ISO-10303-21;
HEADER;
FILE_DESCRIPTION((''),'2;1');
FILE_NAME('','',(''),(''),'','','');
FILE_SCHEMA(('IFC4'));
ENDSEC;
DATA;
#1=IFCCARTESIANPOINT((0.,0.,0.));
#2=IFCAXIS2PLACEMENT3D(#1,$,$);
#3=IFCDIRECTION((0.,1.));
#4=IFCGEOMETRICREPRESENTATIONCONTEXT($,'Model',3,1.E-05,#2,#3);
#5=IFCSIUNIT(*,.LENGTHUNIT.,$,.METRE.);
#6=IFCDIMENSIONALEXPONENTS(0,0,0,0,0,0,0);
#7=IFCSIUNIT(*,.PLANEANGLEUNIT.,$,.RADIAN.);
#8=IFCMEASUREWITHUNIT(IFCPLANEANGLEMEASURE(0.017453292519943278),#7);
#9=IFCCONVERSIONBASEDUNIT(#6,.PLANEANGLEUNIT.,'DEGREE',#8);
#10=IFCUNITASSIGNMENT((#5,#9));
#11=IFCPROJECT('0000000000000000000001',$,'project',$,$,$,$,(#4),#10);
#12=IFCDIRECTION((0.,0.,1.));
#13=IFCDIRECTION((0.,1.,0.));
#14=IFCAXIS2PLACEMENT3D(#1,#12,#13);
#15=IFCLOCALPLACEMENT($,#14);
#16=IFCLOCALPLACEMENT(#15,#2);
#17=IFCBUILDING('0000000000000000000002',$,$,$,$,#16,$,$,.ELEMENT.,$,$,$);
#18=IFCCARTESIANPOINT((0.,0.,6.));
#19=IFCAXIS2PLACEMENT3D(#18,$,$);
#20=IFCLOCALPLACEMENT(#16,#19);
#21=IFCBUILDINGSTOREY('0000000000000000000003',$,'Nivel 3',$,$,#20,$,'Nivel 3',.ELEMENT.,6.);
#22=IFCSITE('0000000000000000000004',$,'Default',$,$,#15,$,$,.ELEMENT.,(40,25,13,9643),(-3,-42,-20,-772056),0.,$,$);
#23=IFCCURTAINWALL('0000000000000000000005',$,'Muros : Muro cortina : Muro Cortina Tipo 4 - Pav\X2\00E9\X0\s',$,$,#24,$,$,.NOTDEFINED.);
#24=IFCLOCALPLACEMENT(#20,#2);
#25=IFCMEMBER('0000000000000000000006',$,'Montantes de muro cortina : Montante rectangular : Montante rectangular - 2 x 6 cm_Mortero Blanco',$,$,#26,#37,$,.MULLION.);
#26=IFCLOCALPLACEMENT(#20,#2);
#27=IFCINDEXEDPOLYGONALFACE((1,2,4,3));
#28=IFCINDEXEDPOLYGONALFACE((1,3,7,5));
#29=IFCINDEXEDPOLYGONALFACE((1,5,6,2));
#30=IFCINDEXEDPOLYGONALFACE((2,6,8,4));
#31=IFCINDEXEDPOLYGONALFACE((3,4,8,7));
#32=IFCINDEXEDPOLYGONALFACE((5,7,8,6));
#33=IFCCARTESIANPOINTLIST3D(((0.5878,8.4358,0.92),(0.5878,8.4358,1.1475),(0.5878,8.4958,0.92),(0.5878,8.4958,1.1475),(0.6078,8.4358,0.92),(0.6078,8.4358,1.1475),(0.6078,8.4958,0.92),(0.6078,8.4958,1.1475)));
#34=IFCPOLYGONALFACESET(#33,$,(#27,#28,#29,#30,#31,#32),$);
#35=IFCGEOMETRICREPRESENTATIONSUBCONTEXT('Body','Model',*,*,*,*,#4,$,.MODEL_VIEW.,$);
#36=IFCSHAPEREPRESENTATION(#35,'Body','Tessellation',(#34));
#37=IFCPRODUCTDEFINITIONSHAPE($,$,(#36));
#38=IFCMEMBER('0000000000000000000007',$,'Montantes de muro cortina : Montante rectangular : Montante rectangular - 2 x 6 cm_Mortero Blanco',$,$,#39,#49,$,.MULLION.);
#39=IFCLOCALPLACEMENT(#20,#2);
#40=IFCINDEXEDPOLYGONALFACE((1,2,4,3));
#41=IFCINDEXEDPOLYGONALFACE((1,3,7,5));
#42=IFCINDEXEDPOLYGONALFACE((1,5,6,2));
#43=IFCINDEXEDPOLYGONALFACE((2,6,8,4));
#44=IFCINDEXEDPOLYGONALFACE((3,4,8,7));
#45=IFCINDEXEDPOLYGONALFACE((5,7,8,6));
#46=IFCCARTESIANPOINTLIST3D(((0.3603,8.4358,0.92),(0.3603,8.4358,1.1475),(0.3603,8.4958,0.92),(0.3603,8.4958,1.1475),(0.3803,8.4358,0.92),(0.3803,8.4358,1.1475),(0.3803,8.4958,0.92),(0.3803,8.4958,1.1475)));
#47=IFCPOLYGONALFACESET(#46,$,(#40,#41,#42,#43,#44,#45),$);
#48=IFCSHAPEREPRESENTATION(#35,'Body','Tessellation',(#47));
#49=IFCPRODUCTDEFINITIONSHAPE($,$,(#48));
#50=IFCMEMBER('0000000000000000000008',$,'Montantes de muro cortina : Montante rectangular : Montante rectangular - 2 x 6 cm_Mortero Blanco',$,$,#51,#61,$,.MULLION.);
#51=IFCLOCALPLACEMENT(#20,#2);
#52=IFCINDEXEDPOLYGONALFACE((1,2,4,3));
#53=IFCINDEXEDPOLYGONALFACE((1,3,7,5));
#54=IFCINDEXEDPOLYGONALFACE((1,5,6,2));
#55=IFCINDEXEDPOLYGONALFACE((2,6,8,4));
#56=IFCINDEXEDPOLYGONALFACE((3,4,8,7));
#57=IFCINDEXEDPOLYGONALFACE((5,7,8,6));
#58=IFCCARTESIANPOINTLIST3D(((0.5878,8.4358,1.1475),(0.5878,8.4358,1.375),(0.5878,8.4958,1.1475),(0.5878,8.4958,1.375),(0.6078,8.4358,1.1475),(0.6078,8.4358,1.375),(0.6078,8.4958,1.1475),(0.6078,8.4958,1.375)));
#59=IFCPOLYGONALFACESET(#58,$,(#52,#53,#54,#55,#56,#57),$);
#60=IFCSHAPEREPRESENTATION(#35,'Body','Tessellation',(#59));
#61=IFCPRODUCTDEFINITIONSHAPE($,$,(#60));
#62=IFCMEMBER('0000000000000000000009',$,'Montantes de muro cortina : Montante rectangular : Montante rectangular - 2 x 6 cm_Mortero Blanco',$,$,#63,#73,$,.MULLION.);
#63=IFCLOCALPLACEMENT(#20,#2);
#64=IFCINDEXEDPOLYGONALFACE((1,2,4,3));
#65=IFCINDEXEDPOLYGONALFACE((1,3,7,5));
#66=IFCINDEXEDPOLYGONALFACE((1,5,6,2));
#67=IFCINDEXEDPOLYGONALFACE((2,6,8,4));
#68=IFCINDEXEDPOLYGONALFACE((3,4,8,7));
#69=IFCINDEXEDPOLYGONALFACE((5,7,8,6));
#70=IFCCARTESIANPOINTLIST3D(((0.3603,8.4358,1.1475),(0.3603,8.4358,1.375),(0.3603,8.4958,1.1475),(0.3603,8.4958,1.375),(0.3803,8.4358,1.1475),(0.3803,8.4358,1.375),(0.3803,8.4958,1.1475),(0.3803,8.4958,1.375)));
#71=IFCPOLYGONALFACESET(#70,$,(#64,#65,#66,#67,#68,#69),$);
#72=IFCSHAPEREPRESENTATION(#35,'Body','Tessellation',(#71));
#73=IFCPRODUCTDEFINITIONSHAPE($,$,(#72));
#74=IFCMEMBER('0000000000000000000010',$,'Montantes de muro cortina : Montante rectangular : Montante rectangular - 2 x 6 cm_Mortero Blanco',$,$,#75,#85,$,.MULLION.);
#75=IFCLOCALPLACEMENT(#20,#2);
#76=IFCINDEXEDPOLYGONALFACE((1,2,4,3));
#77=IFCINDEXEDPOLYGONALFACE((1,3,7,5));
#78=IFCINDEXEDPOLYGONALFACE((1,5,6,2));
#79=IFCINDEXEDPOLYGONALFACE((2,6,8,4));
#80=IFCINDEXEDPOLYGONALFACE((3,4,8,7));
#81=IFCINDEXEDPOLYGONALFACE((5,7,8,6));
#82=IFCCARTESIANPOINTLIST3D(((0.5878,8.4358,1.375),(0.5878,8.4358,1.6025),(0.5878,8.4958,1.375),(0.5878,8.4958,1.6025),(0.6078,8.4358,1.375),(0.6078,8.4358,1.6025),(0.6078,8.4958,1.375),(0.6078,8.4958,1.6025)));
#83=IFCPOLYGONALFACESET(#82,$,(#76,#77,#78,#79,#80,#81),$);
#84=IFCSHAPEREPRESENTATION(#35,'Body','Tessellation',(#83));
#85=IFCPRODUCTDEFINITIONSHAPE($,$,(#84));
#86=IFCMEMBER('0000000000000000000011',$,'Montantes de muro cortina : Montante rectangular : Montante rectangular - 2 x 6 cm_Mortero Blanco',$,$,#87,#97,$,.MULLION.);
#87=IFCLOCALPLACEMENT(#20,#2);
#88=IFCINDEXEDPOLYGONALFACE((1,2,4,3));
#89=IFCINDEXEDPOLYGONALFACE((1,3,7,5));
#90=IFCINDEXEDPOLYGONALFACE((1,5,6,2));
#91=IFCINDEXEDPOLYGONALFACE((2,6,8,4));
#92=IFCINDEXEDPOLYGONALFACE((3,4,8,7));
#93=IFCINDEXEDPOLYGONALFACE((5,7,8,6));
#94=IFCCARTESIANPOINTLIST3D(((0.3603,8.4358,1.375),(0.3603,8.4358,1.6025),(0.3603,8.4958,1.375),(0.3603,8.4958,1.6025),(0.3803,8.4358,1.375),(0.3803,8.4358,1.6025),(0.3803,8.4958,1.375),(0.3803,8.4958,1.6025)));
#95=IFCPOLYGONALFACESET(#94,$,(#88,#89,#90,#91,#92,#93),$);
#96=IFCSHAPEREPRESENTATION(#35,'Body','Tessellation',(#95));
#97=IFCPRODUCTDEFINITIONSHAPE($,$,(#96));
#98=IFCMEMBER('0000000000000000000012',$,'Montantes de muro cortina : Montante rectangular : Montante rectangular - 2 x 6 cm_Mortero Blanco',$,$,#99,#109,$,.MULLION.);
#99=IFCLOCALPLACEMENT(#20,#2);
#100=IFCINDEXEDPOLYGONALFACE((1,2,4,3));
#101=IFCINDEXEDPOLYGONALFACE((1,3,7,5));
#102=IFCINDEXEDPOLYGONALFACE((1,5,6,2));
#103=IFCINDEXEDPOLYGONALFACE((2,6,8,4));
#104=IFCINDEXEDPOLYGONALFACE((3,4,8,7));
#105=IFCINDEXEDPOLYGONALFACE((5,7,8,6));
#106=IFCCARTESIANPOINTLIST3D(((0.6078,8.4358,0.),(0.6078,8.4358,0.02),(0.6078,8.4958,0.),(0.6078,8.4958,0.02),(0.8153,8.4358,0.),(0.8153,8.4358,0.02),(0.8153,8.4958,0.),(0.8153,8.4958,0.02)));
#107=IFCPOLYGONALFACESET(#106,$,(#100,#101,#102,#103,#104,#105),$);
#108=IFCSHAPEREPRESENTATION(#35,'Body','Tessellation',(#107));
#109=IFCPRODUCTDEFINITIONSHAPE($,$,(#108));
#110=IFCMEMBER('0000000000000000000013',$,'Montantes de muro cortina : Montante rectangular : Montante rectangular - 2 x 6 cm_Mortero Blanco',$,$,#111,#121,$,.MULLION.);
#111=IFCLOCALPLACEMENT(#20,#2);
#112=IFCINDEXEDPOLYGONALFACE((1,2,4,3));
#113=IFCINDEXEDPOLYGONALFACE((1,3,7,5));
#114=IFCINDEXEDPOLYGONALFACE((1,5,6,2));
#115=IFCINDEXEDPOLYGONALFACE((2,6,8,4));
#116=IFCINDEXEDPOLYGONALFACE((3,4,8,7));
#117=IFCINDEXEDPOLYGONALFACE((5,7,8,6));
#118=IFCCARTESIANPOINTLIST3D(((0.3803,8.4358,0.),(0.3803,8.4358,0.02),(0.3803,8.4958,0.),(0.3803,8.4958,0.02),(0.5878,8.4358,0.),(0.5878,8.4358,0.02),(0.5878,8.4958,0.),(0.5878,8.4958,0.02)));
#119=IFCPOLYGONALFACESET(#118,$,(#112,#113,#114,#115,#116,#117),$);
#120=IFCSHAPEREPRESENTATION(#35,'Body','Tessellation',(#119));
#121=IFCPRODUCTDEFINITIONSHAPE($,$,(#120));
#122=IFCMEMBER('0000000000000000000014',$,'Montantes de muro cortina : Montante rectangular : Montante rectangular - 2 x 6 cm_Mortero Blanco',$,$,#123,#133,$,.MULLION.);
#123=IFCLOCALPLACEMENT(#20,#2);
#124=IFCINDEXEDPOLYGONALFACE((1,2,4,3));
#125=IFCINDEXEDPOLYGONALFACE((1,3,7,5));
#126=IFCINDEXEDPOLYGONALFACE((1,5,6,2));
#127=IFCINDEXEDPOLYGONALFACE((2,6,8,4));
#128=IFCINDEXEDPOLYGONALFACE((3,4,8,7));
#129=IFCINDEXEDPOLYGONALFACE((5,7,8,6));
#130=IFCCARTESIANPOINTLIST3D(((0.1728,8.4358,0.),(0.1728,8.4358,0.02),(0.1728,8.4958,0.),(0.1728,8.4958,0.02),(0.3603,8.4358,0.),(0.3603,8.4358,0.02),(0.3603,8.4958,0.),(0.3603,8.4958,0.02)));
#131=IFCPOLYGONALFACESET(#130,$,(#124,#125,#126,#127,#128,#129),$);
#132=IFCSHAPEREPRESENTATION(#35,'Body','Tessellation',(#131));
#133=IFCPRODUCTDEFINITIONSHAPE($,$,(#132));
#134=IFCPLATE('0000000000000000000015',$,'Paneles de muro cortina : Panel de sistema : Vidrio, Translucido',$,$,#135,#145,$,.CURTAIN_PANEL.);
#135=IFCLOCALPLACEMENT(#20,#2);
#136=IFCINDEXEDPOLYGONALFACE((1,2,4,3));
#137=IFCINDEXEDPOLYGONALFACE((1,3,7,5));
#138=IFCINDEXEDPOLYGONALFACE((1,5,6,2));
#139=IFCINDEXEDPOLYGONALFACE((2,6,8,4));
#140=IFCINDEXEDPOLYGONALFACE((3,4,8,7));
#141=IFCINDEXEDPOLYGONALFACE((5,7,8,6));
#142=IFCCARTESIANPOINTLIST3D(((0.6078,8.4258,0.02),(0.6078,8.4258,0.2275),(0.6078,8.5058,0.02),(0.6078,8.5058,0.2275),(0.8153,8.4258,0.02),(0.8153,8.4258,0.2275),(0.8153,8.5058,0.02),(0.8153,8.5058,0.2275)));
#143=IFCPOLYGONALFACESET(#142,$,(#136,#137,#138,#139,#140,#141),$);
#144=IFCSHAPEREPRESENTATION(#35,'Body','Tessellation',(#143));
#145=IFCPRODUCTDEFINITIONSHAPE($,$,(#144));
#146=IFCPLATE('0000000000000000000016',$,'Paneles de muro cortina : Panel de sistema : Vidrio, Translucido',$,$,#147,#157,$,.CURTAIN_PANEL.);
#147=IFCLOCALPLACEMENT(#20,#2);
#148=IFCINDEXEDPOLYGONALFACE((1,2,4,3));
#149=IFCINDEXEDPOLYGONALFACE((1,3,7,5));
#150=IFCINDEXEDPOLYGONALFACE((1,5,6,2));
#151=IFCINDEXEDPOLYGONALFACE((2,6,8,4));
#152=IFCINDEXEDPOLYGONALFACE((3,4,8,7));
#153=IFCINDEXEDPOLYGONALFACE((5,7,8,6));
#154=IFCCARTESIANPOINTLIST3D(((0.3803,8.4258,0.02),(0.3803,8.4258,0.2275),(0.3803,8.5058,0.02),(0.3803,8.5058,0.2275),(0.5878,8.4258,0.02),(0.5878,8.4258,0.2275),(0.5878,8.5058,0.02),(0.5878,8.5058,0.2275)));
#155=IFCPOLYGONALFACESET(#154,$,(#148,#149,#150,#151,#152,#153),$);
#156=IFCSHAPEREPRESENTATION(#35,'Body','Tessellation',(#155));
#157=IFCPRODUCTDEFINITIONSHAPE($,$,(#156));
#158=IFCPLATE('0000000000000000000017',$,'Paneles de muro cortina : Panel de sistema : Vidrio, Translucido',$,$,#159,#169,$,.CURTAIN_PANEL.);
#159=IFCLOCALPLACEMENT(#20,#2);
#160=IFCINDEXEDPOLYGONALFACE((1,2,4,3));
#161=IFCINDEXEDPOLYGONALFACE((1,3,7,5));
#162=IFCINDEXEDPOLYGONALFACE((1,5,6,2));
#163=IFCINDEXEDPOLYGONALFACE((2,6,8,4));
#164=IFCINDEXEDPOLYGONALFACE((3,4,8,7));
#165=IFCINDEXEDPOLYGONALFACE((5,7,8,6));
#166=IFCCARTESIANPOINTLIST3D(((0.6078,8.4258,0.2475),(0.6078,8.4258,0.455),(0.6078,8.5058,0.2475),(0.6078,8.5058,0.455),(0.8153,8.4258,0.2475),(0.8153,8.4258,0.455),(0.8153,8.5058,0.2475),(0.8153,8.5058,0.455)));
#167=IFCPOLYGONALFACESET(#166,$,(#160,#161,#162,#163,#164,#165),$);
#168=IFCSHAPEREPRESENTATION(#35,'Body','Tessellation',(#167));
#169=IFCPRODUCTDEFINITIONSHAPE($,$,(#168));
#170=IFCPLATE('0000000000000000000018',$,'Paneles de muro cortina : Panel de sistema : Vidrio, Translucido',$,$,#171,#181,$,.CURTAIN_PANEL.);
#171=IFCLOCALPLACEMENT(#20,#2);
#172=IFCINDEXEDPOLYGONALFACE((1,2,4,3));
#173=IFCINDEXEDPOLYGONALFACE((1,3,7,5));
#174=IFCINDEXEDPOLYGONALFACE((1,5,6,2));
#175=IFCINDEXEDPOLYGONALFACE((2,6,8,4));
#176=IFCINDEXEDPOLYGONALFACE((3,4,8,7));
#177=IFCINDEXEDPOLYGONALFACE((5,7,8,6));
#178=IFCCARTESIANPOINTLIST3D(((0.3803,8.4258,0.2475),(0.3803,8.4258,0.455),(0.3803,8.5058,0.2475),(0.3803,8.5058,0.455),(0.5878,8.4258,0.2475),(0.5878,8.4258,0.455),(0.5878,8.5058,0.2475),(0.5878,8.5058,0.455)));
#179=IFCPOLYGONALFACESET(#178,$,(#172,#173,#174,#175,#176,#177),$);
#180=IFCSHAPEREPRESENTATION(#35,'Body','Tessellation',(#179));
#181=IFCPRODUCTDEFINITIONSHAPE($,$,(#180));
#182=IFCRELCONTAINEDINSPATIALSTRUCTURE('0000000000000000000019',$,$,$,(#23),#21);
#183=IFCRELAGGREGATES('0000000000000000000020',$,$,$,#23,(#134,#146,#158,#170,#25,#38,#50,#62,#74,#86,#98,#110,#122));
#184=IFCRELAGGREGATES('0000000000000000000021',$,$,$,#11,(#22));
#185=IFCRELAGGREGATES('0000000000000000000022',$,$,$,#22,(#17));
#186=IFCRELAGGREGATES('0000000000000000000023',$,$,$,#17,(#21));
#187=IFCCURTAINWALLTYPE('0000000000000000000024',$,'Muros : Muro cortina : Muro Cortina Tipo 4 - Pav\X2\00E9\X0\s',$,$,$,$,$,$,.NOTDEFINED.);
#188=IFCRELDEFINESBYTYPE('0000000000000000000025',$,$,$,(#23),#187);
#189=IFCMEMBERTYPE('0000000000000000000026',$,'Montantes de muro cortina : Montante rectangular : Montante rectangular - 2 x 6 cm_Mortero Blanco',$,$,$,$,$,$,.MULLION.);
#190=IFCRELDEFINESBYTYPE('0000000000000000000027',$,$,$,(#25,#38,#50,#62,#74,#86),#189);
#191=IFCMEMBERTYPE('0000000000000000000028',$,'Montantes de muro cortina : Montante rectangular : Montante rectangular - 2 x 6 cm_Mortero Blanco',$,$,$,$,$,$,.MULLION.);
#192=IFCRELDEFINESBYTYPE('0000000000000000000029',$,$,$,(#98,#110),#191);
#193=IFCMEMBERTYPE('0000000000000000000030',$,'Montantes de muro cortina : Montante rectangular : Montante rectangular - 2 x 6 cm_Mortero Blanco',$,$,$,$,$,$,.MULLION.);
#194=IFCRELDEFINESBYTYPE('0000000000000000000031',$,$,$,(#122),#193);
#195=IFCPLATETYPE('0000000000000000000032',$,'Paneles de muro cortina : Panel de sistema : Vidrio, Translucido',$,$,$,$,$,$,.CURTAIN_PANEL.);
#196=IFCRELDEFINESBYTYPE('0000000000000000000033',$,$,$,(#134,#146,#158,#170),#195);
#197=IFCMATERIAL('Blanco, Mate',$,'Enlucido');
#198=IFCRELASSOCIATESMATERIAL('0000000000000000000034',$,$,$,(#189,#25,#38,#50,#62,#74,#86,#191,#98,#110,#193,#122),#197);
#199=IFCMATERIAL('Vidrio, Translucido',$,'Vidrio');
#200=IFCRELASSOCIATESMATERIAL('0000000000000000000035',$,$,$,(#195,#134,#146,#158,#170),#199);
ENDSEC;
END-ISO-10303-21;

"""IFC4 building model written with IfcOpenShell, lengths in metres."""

from ifc_helpers import new_model, entity, si_unit, converted_unit, direction, frame, origin, place, context, subcontext, project, spatial, indexed_curve, outline, extrude, source, transform, mapped, material, type_object, type_shapes, element, aggregate, save


model = new_model("IFC4")

# Units and contexts
model_context = context("Model", 3, precision=1e-05, world=origin(), true_north=direction((0.0, 1.0)))
body_context = subcontext(model_context, "Body", "Model", "MODEL_VIEW")
ifc_project = project(units=[si_unit("LENGTHUNIT", "METRE"), converted_unit("PLANEANGLEUNIT", "DEGREE", entity("IfcPlaneAngleMeasure", 0.017453292519943278), si_unit("PLANEANGLEUNIT", "RADIAN"), dimensions=[0, 0, 0, 0, 0, 0, 0])], contexts=[model_context])

# Site, building, storey
site_placement = place(None, frame((0.0, 0.0, 0.0), z_axis=(0.0, 0.0, 1.0), x_axis=(0.0, 1.0, 0.0)))
site = spatial("IfcSite", under=ifc_project, at=site_placement, Name="Default", CompositionType="ELEMENT", RefLatitude=(40, 25, 13, 9643), RefLongitude=(-3, -42, -20, -772056), RefElevation=0.0)
building_placement = place(site_placement, origin())
building = spatial("IfcBuilding", under=site, at=building_placement, CompositionType="ELEMENT")
storey_placement = place(building_placement, frame((0.0, 0.0, 6.0)))
storey = spatial("IfcBuildingStorey", under=building, at=storey_placement, Name="Nivel 3", LongName="Nivel 3", CompositionType="ELEMENT", Elevation=6.0)

# Curtain wall, members, plates
curtain_wall_type = type_object("IfcCurtainWallType", Name="Muros : Muro cortina : Muro Cortina Tipo 4 - Pavés", PredefinedType="NOTDEFINED")
curtain_wall_placement = place(storey_placement, frame((0.0, 0.0, -6.0)))
curtain_wall = element("IfcCurtainWall", 1, at=curtain_wall_placement, inside=storey, type_object=curtain_wall_type, Name="Muros : Muro cortina : Muro Cortina Tipo 4 - Pavés", PredefinedType="NOTDEFINED")
ifc_material_1 = material(Name="Blanco, Mate", Category="Enlucido")
member_type_1 = type_object("IfcMemberType", Name="Montantes de muro cortina : Montante rectangular : Montante rectangular - 2 x 6 cm_Mortero Blanco", PredefinedType="MULLION", material=ifc_material_1)
shared_shape_1 = source(origin(), body_context, "Body", "SweptSolid", [
    extrude(outline(indexed_curve([(-0.01, -0.03), (0.01, -0.03), (0.01, 0.03), (-0.01, 0.03), (-0.01, -0.03)], self_intersect=False)), frame((0.0, 0.0, -0.2275), z_axis=(0.0, 0.0, 1.0), x_axis=(-1.0, 0.0, 0.0)), (0.0, 0.0, 1.0), 0.2275),
])
type_shapes(member_type_1, [shared_shape_1])
member_1_placement = place(curtain_wall_placement, frame((0.5978, 8.4658, 6.92), z_axis=(0.0, 0.0, -1.0), x_axis=(-1.0, 0.0, 0.0)))
member_1 = element("IfcMember", 2, at=member_1_placement, type_object=member_type_1, material=ifc_material_1, Name="Montantes de muro cortina : Montante rectangular : Montante rectangular - 2 x 6 cm_Mortero Blanco", PredefinedType="MULLION", context=body_context, shape_type="MappedRepresentation", body=[
    mapped(shared_shape_1, transform((0.0, 0.0, 0.0), scale=1.0)),
])
member_2_placement = place(curtain_wall_placement, frame((0.3703, 8.4658, 6.92), z_axis=(0.0, 0.0, -1.0), x_axis=(-1.0, 0.0, 0.0)))
member_2 = element("IfcMember", 3, at=member_2_placement, type_object=member_type_1, material=ifc_material_1, Name="Montantes de muro cortina : Montante rectangular : Montante rectangular - 2 x 6 cm_Mortero Blanco", PredefinedType="MULLION", context=body_context, shape_type="MappedRepresentation", body=[
    mapped(shared_shape_1, transform((0.0, 0.0, 0.0), scale=1.0)),
])
member_3_placement = place(curtain_wall_placement, frame((0.5978, 8.4658, 7.1475), z_axis=(0.0, 0.0, -1.0), x_axis=(-1.0, 0.0, 0.0)))
member_3 = element("IfcMember", 4, at=member_3_placement, type_object=member_type_1, material=ifc_material_1, Name="Montantes de muro cortina : Montante rectangular : Montante rectangular - 2 x 6 cm_Mortero Blanco", PredefinedType="MULLION", context=body_context, shape_type="MappedRepresentation", body=[
    mapped(shared_shape_1, transform((0.0, 0.0, 0.0), scale=1.0)),
])
member_4_placement = place(curtain_wall_placement, frame((0.3703, 8.4658, 7.1475), z_axis=(0.0, 0.0, -1.0), x_axis=(-1.0, 0.0, 0.0)))
member_4 = element("IfcMember", 5, at=member_4_placement, type_object=member_type_1, material=ifc_material_1, Name="Montantes de muro cortina : Montante rectangular : Montante rectangular - 2 x 6 cm_Mortero Blanco", PredefinedType="MULLION", context=body_context, shape_type="MappedRepresentation", body=[
    mapped(shared_shape_1, transform((0.0, 0.0, 0.0), scale=1.0)),
])
member_5_placement = place(curtain_wall_placement, frame((0.5978, 8.4658, 7.375), z_axis=(0.0, 0.0, -1.0), x_axis=(-1.0, 0.0, 0.0)))
member_5 = element("IfcMember", 6, at=member_5_placement, type_object=member_type_1, material=ifc_material_1, Name="Montantes de muro cortina : Montante rectangular : Montante rectangular - 2 x 6 cm_Mortero Blanco", PredefinedType="MULLION", context=body_context, shape_type="MappedRepresentation", body=[
    mapped(shared_shape_1, transform((0.0, 0.0, 0.0), scale=1.0)),
])
member_6_placement = place(curtain_wall_placement, frame((0.3703, 8.4658, 7.375), z_axis=(0.0, 0.0, -1.0), x_axis=(-1.0, 0.0, 0.0)))
member_6 = element("IfcMember", 7, at=member_6_placement, type_object=member_type_1, material=ifc_material_1, Name="Montantes de muro cortina : Montante rectangular : Montante rectangular - 2 x 6 cm_Mortero Blanco", PredefinedType="MULLION", context=body_context, shape_type="MappedRepresentation", body=[
    mapped(shared_shape_1, transform((0.0, 0.0, 0.0), scale=1.0)),
])
member_type_2 = type_object("IfcMemberType", Name="Montantes de muro cortina : Montante rectangular : Montante rectangular - 2 x 6 cm_Mortero Blanco", PredefinedType="MULLION", material=ifc_material_1)
shared_shape_2 = source(origin(), body_context, "Body", "SweptSolid", [
    extrude(outline(indexed_curve([(-0.01, -0.03), (0.01, -0.03), (0.01, 0.03), (-0.01, 0.03), (-0.01, -0.03)], self_intersect=False)), frame((-0.01, 0.0, -0.2075), z_axis=(0.0, 0.0, 1.0), x_axis=(-1.0, 0.0, 0.0)), (0.0, 0.0, 1.0), 0.2075),
])
type_shapes(member_type_2, [shared_shape_2])
member_7_placement = place(curtain_wall_placement, frame((0.8153, 8.4658, 6.0), z_axis=(1.0, 0.0, 0.0), x_axis=(0.0, 0.0, -1.0)))
member_7 = element("IfcMember", 8, at=member_7_placement, type_object=member_type_2, material=ifc_material_1, Name="Montantes de muro cortina : Montante rectangular : Montante rectangular - 2 x 6 cm_Mortero Blanco", PredefinedType="MULLION", context=body_context, shape_type="MappedRepresentation", body=[
    mapped(shared_shape_2, transform((0.0, 0.0, 0.0), scale=1.0)),
])
member_8_placement = place(curtain_wall_placement, frame((0.5878, 8.4658, 6.0), z_axis=(1.0, 0.0, 0.0), x_axis=(0.0, 0.0, -1.0)))
member_8 = element("IfcMember", 9, at=member_8_placement, type_object=member_type_2, material=ifc_material_1, Name="Montantes de muro cortina : Montante rectangular : Montante rectangular - 2 x 6 cm_Mortero Blanco", PredefinedType="MULLION", context=body_context, shape_type="MappedRepresentation", body=[
    mapped(shared_shape_2, transform((0.0, 0.0, 0.0), scale=1.0)),
])
member_type_3 = type_object("IfcMemberType", Name="Montantes de muro cortina : Montante rectangular : Montante rectangular - 2 x 6 cm_Mortero Blanco", PredefinedType="MULLION", material=ifc_material_1)
shared_shape_3 = source(origin(), body_context, "Body", "SweptSolid", [
    extrude(outline(indexed_curve([(-0.01, -0.03), (0.01, -0.03), (0.01, 0.03), (-0.01, 0.03), (-0.01, -0.03)], self_intersect=False)), frame((-0.01, 0.0, -0.1875), z_axis=(0.0, 0.0, 1.0), x_axis=(-1.0, 0.0, 0.0)), (0.0, 0.0, 1.0), 0.1875),
])
type_shapes(member_type_3, [shared_shape_3])
member_9_placement = place(curtain_wall_placement, frame((0.3603, 8.4658, 6.0), z_axis=(1.0, 0.0, 0.0), x_axis=(0.0, 0.0, -1.0)))
member_9 = element("IfcMember", 10, at=member_9_placement, type_object=member_type_3, material=ifc_material_1, Name="Montantes de muro cortina : Montante rectangular : Montante rectangular - 2 x 6 cm_Mortero Blanco", PredefinedType="MULLION", context=body_context, shape_type="MappedRepresentation", body=[
    mapped(shared_shape_3, transform((0.0, 0.0, 0.0), scale=1.0)),
])
ifc_material_2 = material(Name="Vidrio, Translucido", Category="Vidrio")
plate_type = type_object("IfcPlateType", Name="Paneles de muro cortina : Panel de sistema : Vidrio, Translucido", PredefinedType="CURTAIN_PANEL", material=ifc_material_2)
shared_shape_4 = source(origin(), body_context, "Body", "SweptSolid", [
    extrude(outline(indexed_curve([(-0.04, -0.1038), (0.04, -0.1038), (0.04, 0.1038), (-0.04, 0.1038), (-0.04, -0.1038)], self_intersect=False)), frame((0.0, 0.0, 0.0), z_axis=(0.0, 0.0, 1.0), x_axis=(0.0, 1.0, 0.0)), (0.0, 0.0, 1.0), 0.2075),
])
type_shapes(plate_type, [shared_shape_4])
plate_1_placement = place(curtain_wall_placement, frame((0.7115, 8.4658, 6.02), z_axis=(0.0, 0.0, 1.0), x_axis=(-1.0, 0.0, 0.0)))
plate_1 = element("IfcPlate", 11, at=plate_1_placement, type_object=plate_type, material=ifc_material_2, Name="Paneles de muro cortina : Panel de sistema : Vidrio, Translucido", PredefinedType="CURTAIN_PANEL", context=body_context, shape_type="MappedRepresentation", body=[
    mapped(shared_shape_4, transform((0.0, 0.0, 0.0), scale=1.0)),
])
plate_2_placement = place(curtain_wall_placement, frame((0.484, 8.4658, 6.02), z_axis=(0.0, 0.0, 1.0), x_axis=(-1.0, 0.0, 0.0)))
plate_2 = element("IfcPlate", 12, at=plate_2_placement, type_object=plate_type, material=ifc_material_2, Name="Paneles de muro cortina : Panel de sistema : Vidrio, Translucido", PredefinedType="CURTAIN_PANEL", context=body_context, shape_type="MappedRepresentation", body=[
    mapped(shared_shape_4, transform((0.0, 0.0, 0.0), scale=1.0)),
])
plate_3_placement = place(curtain_wall_placement, frame((0.7115, 8.4658, 6.2475), z_axis=(0.0, 0.0, 1.0), x_axis=(-1.0, 0.0, 0.0)))
plate_3 = element("IfcPlate", 13, at=plate_3_placement, type_object=plate_type, material=ifc_material_2, Name="Paneles de muro cortina : Panel de sistema : Vidrio, Translucido", PredefinedType="CURTAIN_PANEL", context=body_context, shape_type="MappedRepresentation", body=[
    mapped(shared_shape_4, transform((0.0, 0.0, 0.0), scale=1.0)),
])
plate_4_placement = place(curtain_wall_placement, frame((0.484, 8.4658, 6.2475), z_axis=(0.0, 0.0, 1.0), x_axis=(-1.0, 0.0, 0.0)))
plate_4 = element("IfcPlate", 14, at=plate_4_placement, type_object=plate_type, material=ifc_material_2, Name="Paneles de muro cortina : Panel de sistema : Vidrio, Translucido", PredefinedType="CURTAIN_PANEL", context=body_context, shape_type="MappedRepresentation", body=[
    mapped(shared_shape_4, transform((0.0, 0.0, 0.0), scale=1.0)),
])
aggregate(curtain_wall, [plate_1, plate_2, plate_3, plate_4, member_1, member_2, member_3, member_4, member_5, member_6, member_7, member_8, member_9])

save(model, "model.ifc")
